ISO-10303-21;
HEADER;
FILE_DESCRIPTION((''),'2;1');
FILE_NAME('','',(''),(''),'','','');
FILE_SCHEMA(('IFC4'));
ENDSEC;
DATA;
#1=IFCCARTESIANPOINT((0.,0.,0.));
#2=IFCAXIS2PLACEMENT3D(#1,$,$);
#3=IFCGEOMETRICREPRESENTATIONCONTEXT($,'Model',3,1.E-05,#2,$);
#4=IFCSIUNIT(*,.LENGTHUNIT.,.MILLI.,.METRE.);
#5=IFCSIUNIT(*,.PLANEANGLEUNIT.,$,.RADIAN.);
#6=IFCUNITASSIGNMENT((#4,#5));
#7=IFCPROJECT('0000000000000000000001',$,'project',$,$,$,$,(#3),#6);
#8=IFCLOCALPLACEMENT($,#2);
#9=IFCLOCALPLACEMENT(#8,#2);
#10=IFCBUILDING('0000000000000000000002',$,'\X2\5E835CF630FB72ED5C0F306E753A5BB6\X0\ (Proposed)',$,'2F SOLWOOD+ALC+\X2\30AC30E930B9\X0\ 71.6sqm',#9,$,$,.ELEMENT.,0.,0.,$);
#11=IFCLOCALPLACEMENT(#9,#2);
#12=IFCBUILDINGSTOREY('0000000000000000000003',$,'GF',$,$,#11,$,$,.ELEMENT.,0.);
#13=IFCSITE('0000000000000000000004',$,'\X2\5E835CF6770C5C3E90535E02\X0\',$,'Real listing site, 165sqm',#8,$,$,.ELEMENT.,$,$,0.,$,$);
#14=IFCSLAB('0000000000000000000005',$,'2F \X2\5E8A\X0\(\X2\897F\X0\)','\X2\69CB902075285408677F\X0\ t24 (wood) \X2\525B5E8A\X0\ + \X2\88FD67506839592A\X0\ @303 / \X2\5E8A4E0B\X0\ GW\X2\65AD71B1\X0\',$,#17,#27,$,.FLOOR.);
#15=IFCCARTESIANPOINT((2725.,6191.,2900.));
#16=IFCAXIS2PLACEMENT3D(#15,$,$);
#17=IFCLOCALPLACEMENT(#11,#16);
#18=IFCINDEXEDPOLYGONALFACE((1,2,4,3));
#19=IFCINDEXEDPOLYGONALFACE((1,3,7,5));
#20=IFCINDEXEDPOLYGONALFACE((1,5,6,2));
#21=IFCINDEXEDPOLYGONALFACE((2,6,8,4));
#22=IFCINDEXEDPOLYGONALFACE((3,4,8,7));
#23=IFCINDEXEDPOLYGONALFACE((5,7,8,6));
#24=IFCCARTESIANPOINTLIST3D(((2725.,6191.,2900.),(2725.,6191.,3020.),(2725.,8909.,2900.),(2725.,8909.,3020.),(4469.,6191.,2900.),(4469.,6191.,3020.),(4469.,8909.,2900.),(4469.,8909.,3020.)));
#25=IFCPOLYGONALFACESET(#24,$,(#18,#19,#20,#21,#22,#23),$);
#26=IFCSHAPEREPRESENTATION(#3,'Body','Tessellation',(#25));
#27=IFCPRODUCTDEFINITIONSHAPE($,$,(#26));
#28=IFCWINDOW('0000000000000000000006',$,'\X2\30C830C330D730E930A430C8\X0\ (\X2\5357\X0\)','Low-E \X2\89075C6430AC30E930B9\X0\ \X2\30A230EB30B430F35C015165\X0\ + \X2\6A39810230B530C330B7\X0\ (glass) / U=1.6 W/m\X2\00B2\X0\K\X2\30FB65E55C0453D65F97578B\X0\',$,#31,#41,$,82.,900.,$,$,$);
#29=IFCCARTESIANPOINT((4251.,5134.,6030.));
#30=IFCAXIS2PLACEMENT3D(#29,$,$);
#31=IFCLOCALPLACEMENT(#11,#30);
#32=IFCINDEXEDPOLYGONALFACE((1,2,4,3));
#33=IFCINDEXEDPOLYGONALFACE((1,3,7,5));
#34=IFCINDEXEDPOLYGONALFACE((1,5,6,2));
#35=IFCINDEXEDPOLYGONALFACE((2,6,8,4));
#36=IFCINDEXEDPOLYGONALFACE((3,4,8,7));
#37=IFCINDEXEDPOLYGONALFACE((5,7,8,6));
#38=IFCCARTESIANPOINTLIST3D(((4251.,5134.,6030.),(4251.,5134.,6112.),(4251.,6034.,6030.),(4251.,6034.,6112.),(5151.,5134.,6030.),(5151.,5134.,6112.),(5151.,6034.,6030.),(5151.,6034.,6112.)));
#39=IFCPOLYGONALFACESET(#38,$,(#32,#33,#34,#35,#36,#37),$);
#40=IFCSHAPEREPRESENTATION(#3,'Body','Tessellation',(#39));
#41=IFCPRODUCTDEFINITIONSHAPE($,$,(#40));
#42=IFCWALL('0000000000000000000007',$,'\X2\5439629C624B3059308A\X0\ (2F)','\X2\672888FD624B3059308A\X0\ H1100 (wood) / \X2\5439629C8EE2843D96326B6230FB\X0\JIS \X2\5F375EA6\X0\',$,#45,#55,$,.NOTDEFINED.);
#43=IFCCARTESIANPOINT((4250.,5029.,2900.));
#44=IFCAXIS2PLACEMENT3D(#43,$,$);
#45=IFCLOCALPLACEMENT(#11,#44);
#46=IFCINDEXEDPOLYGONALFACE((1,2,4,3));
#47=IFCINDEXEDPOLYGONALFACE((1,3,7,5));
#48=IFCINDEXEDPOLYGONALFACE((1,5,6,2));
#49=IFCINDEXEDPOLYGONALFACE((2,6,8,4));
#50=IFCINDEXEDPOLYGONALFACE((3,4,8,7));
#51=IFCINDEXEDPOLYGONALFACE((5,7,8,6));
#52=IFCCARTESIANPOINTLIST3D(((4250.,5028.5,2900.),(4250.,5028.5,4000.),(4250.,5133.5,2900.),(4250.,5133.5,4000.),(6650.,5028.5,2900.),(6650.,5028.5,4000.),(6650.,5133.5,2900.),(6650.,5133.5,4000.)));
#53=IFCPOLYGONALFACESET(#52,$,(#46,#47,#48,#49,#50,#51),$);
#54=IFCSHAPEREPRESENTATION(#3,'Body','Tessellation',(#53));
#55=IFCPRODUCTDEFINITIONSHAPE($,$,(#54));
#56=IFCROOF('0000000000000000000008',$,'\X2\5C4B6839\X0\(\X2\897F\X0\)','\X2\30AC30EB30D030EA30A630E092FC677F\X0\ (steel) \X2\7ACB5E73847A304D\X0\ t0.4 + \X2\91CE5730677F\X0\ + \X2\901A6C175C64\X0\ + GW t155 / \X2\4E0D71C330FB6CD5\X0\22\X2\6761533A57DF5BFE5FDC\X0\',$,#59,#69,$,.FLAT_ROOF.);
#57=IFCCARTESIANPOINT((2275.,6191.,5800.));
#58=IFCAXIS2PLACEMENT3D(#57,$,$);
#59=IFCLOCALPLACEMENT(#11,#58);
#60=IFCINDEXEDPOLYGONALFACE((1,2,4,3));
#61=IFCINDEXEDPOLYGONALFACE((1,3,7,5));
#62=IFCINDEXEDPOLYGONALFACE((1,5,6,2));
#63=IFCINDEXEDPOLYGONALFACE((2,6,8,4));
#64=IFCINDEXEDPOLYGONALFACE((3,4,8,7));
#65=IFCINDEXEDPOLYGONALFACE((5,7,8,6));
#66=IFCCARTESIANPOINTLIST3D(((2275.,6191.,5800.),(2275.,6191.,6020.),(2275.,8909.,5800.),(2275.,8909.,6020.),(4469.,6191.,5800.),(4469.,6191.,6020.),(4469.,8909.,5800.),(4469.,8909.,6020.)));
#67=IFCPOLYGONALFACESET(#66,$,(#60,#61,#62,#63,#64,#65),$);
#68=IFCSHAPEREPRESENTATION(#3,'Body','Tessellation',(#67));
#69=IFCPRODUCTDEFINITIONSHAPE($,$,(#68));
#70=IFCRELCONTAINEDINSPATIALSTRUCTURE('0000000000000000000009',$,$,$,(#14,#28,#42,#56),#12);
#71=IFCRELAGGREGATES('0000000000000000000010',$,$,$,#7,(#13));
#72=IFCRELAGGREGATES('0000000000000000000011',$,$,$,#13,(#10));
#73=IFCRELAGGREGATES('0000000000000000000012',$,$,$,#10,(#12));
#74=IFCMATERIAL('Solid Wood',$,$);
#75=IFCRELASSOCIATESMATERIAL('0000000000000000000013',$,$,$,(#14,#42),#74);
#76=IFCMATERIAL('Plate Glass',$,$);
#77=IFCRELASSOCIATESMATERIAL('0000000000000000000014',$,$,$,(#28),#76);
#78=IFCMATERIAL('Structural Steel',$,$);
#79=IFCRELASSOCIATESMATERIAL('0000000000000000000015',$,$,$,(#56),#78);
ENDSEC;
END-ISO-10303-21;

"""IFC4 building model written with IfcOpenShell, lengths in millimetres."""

from ifc_helpers import new_model, si_unit, frame, frame_2d, origin, place, context, project, spatial, rectangle, extrude, material, element, save


model = new_model("IFC4")

# Units and contexts
model_context = context("Model", 3, precision=1e-05, world=origin())
ifc_project = project(units=[si_unit("LENGTHUNIT", "METRE", prefix="MILLI"), si_unit("PLANEANGLEUNIT", "RADIAN")], contexts=[model_context])

# Site, building, storey
site_placement = place(None, origin())
site = spatial("IfcSite", under=ifc_project, at=site_placement, Name="広島県尾道市", ObjectType="Real listing site, 165sqm", CompositionType="ELEMENT", RefElevation=0.0)
building_placement = place(site_placement, origin())
building = spatial("IfcBuilding", under=site, at=building_placement, Name="広島・狭小の町家 (Proposed)", ObjectType="2F SOLWOOD+ALC+ガラス 71.6sqm", CompositionType="ELEMENT", ElevationOfRefHeight=0.0, ElevationOfTerrain=0.0)
storey_placement = place(building_placement, origin())
storey = spatial("IfcBuildingStorey", under=building, at=storey_placement, Name="GF", CompositionType="ELEMENT", Elevation=0.0)

# Shared definitions
ifc_material_1 = material(Name="Solid Wood")

# Slab
slab_1_placement = place(storey_placement, frame((2725.0, 6191.0, 2900.0)))
element("IfcSlab", 1, at=slab_1_placement, inside=storey, material=ifc_material_1, Name="2F 床(西)", Description="構造用合板 t24 (wood) 剛床 + 製材根太 @303 / 床下 GW断熱", PredefinedType="FLOOR", context=model_context, shape_type="SweptSolid", body=[
    extrude(rectangle(XDim=1744.0, YDim=2718.0, at=frame_2d((872.0, 1359.0))), frame((2725.0, 6191.0, 2900.0)), (0.0, 0.0, 1.0), 120.0),
])

# Window
ifc_material_2 = material(Name="Plate Glass")
window_placement = place(storey_placement, frame((4251.0, 5134.0, 6030.0)))
element("IfcWindow", 2, at=window_placement, inside=storey, material=ifc_material_2, Name="トップライト (南)", Description="Low-E 複層ガラス アルゴン封入 + 樹脂サッシ (glass) / U=1.6 W/m²K・日射取得型", OverallHeight=82.0, OverallWidth=900.0, context=model_context, shape_type="SweptSolid", body=[
    extrude(rectangle(XDim=900.0, YDim=900.0, at=frame_2d((450.0, 450.0))), frame((4251.0, 5134.0, 6030.0)), (0.0, 0.0, 1.0), 82.0),
])

# Wall
wall_placement = place(storey_placement, frame((4250.0, 5029.0, 2900.0)))
element("IfcWall", 3, at=wall_placement, inside=storey, material=ifc_material_1, Name="吹抜手すり (2F)", Description="木製手すり H1100 (wood) / 吹抜転落防止・JIS 強度", PredefinedType="NOTDEFINED", context=model_context, shape_type="SweptSolid", body=[
    extrude(rectangle(XDim=2400.0, YDim=105.0, at=frame_2d((1200.0, 52.0))), frame((4250.0, 5029.0, 2900.0)), (0.0, 0.0, 1.0), 1100.0),
])

# Roof
ifc_material_3 = material(Name="Structural Steel")
for number, where, name in (
    (4, (2275.0, 6191.0, 5800.0), "屋根(西)"),
):
    element("IfcRoof", number, at=place(storey_placement, frame(where)), inside=storey, material=ifc_material_3, Name=name, Description="ガルバリウム鋼板 (steel) 立平葺き t0.4 + 野地板 + 通気層 + GW t155 / 不燃・法22条区域対応", PredefinedType="FLAT_ROOF", context=model_context, shape_type="SweptSolid", body=[
        extrude(rectangle(XDim=2194.0, YDim=2718.0, at=frame_2d((1097.0, 1359.0))), frame((2275.0, 6191.0, 5800.0)), (0.0, 0.0, 1.0), 220.0),
    ])

save(model, "model.ifc")
